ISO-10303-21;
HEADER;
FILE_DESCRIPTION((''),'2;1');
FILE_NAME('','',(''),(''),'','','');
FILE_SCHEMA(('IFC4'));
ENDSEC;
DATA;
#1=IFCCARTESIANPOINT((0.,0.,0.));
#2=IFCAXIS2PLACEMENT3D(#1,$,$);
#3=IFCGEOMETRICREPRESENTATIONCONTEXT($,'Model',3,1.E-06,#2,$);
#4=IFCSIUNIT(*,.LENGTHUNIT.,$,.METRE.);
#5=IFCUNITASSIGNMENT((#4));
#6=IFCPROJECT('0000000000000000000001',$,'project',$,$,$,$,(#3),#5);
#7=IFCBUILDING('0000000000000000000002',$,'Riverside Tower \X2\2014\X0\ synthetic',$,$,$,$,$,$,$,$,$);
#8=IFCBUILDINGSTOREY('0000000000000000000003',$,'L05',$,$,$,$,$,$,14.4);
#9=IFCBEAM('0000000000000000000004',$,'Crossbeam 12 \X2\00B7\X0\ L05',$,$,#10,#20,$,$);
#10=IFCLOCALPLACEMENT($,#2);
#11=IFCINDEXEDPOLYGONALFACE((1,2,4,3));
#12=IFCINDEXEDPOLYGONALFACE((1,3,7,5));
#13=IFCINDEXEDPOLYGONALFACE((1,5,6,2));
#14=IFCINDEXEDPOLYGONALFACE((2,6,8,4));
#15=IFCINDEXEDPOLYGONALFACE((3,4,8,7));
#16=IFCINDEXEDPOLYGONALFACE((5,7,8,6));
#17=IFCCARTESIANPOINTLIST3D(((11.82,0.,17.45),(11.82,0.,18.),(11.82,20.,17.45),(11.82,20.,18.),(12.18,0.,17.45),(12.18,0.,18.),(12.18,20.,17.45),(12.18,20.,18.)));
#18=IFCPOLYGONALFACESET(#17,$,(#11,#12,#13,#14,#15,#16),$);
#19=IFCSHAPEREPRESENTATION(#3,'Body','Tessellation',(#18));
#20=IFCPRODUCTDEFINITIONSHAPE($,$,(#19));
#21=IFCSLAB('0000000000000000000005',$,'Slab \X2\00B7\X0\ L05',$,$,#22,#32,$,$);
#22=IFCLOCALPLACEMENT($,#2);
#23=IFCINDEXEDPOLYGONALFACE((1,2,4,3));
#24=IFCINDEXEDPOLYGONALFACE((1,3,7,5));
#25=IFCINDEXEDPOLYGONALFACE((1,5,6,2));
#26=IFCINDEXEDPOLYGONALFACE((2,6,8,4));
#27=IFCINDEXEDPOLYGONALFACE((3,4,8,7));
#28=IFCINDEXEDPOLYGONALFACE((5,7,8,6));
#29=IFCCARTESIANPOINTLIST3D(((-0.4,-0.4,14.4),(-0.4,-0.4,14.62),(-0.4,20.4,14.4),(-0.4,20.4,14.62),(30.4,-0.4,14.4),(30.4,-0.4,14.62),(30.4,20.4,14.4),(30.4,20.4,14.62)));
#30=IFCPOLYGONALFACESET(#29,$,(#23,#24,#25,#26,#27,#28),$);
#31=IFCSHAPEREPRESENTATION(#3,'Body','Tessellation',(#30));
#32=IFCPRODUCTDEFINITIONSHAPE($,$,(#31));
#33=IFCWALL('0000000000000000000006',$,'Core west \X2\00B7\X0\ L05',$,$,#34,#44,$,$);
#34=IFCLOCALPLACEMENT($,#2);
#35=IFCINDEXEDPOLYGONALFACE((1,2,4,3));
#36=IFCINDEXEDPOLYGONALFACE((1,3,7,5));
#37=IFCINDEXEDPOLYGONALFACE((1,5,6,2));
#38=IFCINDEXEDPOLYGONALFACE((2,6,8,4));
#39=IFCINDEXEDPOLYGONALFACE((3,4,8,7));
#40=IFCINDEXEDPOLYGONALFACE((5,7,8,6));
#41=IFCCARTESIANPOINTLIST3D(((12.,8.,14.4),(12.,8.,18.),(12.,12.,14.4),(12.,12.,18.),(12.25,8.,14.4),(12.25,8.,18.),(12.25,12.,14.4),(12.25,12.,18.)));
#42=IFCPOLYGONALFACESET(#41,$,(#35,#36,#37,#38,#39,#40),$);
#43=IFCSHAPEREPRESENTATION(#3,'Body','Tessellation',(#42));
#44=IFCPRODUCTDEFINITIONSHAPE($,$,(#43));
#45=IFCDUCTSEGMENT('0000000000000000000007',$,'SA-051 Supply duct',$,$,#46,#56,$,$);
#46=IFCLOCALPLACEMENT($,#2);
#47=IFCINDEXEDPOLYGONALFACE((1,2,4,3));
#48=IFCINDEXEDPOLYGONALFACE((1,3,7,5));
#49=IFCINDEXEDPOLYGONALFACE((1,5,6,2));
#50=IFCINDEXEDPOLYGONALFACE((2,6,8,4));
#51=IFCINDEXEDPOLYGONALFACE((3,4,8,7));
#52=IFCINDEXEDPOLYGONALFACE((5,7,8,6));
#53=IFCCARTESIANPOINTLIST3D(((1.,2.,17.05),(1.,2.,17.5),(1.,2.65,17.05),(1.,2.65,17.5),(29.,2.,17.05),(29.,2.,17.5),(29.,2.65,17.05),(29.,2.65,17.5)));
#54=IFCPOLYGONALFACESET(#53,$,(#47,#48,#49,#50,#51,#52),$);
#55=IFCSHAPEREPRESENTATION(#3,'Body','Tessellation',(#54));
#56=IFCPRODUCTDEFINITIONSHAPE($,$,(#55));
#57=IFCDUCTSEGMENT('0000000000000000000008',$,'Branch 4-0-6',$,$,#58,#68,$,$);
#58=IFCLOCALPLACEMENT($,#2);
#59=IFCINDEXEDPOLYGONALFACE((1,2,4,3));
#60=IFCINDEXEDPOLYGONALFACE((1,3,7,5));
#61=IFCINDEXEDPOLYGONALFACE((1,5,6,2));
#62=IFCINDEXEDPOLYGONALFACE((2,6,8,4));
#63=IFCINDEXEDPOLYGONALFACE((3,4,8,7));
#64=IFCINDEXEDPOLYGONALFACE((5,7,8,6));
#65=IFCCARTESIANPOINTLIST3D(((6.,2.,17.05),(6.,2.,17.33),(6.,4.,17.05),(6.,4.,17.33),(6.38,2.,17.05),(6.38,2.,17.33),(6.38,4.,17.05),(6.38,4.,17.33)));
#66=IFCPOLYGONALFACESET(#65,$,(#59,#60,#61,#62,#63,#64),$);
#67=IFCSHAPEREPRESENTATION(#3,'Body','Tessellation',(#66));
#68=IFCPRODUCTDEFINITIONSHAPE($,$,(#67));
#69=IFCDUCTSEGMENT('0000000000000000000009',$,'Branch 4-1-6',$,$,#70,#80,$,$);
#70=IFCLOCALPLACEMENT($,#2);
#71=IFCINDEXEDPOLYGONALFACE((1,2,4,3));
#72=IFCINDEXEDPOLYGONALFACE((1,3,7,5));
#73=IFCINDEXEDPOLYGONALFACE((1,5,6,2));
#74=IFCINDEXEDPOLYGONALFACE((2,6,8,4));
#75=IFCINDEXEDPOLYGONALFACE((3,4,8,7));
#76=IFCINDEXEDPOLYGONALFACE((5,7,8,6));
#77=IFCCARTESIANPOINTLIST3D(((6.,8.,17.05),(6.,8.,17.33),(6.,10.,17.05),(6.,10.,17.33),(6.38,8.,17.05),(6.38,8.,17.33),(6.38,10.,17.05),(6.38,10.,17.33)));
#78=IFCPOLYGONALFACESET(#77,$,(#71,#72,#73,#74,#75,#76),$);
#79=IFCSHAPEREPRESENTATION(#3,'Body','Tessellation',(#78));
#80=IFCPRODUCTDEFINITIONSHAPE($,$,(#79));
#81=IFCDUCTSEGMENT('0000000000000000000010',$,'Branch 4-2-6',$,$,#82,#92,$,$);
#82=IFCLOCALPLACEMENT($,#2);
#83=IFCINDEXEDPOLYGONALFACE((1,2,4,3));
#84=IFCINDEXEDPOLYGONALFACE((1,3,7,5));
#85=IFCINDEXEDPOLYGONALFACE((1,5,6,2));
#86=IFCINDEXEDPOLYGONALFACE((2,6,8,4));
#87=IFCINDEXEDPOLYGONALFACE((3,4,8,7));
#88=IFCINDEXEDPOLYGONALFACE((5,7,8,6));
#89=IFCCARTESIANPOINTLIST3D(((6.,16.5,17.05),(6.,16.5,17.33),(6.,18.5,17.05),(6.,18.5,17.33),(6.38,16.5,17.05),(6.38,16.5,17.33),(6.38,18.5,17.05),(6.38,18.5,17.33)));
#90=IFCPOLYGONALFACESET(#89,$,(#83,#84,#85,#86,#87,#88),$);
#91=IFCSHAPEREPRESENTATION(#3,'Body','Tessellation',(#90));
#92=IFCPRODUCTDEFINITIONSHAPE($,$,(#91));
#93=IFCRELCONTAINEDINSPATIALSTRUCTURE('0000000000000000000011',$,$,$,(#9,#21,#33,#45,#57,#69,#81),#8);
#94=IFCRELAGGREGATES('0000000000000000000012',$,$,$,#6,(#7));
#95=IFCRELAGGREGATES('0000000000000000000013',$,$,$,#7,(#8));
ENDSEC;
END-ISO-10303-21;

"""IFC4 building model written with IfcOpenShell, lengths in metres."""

from ifc_helpers import new_model, si_unit, frame, origin, place, context, project, spatial, rectangle, extrude, element, save


model = new_model("IFC4")

# Units and contexts
model_context = context("Model", 3, precision=1e-06, world=origin())
ifc_project = project(units=[si_unit("LENGTHUNIT", "METRE")], contexts=[model_context])

# Building, storey
building = spatial("IfcBuilding", under=ifc_project, Name="Riverside Tower — synthetic")
storey = spatial("IfcBuildingStorey", under=building, Name="L05", Elevation=14.4)

# Beam
for number, where, name in (
    (1, (12.0, 10.0, 17.45), "Crossbeam 12 · L05"),
):
    element("IfcBeam", number, at=place(None, frame(where)), inside=storey, Name=name, context=model_context, shape_type="SweptSolid", body=[
        extrude(rectangle(XDim=0.36, YDim=20.0), origin(), (0.0, 0.0, 1.0), 0.55),
    ])

# Slab
slab_placement = place(None, frame((15.0, 10.0, 14.4)))
element("IfcSlab", 2, at=slab_placement, inside=storey, Name="Slab · L05", context=model_context, shape_type="SweptSolid", body=[
    extrude(rectangle(XDim=30.8, YDim=20.8), origin(), (0.0, 0.0, 1.0), 0.22),
])

# Wall
wall_placement = place(None, frame((12.125, 10.0, 14.4)))
element("IfcWall", 3, at=wall_placement, inside=storey, Name="Core west · L05", context=model_context, shape_type="SweptSolid", body=[
    extrude(rectangle(XDim=0.25, YDim=4.0), origin(), (0.0, 0.0, 1.0), 3.6),
])

# Duct segments
duct_segment_placement = place(None, frame((15.0, 2.325, 17.05)))
element("IfcDuctSegment", 4, at=duct_segment_placement, inside=storey, Name="SA-051 Supply duct", context=model_context, shape_type="SweptSolid", body=[
    extrude(rectangle(XDim=28.0, YDim=0.65), origin(), (0.0, 0.0, 1.0), 0.45),
])
for number, where, name in (
    (5, (6.19, 3.0, 17.05), "Branch 4-0-6"),
    (6, (6.19, 9.0, 17.05), "Branch 4-1-6"),
    (7, (6.19, 17.5, 17.05), "Branch 4-2-6"),
):
    element("IfcDuctSegment", number, at=place(None, frame(where)), inside=storey, Name=name, context=model_context, shape_type="SweptSolid", body=[
        extrude(rectangle(XDim=0.38, YDim=2.0), origin(), (0.0, 0.0, 1.0), 0.28),
    ])

save(model, "model.ifc")
